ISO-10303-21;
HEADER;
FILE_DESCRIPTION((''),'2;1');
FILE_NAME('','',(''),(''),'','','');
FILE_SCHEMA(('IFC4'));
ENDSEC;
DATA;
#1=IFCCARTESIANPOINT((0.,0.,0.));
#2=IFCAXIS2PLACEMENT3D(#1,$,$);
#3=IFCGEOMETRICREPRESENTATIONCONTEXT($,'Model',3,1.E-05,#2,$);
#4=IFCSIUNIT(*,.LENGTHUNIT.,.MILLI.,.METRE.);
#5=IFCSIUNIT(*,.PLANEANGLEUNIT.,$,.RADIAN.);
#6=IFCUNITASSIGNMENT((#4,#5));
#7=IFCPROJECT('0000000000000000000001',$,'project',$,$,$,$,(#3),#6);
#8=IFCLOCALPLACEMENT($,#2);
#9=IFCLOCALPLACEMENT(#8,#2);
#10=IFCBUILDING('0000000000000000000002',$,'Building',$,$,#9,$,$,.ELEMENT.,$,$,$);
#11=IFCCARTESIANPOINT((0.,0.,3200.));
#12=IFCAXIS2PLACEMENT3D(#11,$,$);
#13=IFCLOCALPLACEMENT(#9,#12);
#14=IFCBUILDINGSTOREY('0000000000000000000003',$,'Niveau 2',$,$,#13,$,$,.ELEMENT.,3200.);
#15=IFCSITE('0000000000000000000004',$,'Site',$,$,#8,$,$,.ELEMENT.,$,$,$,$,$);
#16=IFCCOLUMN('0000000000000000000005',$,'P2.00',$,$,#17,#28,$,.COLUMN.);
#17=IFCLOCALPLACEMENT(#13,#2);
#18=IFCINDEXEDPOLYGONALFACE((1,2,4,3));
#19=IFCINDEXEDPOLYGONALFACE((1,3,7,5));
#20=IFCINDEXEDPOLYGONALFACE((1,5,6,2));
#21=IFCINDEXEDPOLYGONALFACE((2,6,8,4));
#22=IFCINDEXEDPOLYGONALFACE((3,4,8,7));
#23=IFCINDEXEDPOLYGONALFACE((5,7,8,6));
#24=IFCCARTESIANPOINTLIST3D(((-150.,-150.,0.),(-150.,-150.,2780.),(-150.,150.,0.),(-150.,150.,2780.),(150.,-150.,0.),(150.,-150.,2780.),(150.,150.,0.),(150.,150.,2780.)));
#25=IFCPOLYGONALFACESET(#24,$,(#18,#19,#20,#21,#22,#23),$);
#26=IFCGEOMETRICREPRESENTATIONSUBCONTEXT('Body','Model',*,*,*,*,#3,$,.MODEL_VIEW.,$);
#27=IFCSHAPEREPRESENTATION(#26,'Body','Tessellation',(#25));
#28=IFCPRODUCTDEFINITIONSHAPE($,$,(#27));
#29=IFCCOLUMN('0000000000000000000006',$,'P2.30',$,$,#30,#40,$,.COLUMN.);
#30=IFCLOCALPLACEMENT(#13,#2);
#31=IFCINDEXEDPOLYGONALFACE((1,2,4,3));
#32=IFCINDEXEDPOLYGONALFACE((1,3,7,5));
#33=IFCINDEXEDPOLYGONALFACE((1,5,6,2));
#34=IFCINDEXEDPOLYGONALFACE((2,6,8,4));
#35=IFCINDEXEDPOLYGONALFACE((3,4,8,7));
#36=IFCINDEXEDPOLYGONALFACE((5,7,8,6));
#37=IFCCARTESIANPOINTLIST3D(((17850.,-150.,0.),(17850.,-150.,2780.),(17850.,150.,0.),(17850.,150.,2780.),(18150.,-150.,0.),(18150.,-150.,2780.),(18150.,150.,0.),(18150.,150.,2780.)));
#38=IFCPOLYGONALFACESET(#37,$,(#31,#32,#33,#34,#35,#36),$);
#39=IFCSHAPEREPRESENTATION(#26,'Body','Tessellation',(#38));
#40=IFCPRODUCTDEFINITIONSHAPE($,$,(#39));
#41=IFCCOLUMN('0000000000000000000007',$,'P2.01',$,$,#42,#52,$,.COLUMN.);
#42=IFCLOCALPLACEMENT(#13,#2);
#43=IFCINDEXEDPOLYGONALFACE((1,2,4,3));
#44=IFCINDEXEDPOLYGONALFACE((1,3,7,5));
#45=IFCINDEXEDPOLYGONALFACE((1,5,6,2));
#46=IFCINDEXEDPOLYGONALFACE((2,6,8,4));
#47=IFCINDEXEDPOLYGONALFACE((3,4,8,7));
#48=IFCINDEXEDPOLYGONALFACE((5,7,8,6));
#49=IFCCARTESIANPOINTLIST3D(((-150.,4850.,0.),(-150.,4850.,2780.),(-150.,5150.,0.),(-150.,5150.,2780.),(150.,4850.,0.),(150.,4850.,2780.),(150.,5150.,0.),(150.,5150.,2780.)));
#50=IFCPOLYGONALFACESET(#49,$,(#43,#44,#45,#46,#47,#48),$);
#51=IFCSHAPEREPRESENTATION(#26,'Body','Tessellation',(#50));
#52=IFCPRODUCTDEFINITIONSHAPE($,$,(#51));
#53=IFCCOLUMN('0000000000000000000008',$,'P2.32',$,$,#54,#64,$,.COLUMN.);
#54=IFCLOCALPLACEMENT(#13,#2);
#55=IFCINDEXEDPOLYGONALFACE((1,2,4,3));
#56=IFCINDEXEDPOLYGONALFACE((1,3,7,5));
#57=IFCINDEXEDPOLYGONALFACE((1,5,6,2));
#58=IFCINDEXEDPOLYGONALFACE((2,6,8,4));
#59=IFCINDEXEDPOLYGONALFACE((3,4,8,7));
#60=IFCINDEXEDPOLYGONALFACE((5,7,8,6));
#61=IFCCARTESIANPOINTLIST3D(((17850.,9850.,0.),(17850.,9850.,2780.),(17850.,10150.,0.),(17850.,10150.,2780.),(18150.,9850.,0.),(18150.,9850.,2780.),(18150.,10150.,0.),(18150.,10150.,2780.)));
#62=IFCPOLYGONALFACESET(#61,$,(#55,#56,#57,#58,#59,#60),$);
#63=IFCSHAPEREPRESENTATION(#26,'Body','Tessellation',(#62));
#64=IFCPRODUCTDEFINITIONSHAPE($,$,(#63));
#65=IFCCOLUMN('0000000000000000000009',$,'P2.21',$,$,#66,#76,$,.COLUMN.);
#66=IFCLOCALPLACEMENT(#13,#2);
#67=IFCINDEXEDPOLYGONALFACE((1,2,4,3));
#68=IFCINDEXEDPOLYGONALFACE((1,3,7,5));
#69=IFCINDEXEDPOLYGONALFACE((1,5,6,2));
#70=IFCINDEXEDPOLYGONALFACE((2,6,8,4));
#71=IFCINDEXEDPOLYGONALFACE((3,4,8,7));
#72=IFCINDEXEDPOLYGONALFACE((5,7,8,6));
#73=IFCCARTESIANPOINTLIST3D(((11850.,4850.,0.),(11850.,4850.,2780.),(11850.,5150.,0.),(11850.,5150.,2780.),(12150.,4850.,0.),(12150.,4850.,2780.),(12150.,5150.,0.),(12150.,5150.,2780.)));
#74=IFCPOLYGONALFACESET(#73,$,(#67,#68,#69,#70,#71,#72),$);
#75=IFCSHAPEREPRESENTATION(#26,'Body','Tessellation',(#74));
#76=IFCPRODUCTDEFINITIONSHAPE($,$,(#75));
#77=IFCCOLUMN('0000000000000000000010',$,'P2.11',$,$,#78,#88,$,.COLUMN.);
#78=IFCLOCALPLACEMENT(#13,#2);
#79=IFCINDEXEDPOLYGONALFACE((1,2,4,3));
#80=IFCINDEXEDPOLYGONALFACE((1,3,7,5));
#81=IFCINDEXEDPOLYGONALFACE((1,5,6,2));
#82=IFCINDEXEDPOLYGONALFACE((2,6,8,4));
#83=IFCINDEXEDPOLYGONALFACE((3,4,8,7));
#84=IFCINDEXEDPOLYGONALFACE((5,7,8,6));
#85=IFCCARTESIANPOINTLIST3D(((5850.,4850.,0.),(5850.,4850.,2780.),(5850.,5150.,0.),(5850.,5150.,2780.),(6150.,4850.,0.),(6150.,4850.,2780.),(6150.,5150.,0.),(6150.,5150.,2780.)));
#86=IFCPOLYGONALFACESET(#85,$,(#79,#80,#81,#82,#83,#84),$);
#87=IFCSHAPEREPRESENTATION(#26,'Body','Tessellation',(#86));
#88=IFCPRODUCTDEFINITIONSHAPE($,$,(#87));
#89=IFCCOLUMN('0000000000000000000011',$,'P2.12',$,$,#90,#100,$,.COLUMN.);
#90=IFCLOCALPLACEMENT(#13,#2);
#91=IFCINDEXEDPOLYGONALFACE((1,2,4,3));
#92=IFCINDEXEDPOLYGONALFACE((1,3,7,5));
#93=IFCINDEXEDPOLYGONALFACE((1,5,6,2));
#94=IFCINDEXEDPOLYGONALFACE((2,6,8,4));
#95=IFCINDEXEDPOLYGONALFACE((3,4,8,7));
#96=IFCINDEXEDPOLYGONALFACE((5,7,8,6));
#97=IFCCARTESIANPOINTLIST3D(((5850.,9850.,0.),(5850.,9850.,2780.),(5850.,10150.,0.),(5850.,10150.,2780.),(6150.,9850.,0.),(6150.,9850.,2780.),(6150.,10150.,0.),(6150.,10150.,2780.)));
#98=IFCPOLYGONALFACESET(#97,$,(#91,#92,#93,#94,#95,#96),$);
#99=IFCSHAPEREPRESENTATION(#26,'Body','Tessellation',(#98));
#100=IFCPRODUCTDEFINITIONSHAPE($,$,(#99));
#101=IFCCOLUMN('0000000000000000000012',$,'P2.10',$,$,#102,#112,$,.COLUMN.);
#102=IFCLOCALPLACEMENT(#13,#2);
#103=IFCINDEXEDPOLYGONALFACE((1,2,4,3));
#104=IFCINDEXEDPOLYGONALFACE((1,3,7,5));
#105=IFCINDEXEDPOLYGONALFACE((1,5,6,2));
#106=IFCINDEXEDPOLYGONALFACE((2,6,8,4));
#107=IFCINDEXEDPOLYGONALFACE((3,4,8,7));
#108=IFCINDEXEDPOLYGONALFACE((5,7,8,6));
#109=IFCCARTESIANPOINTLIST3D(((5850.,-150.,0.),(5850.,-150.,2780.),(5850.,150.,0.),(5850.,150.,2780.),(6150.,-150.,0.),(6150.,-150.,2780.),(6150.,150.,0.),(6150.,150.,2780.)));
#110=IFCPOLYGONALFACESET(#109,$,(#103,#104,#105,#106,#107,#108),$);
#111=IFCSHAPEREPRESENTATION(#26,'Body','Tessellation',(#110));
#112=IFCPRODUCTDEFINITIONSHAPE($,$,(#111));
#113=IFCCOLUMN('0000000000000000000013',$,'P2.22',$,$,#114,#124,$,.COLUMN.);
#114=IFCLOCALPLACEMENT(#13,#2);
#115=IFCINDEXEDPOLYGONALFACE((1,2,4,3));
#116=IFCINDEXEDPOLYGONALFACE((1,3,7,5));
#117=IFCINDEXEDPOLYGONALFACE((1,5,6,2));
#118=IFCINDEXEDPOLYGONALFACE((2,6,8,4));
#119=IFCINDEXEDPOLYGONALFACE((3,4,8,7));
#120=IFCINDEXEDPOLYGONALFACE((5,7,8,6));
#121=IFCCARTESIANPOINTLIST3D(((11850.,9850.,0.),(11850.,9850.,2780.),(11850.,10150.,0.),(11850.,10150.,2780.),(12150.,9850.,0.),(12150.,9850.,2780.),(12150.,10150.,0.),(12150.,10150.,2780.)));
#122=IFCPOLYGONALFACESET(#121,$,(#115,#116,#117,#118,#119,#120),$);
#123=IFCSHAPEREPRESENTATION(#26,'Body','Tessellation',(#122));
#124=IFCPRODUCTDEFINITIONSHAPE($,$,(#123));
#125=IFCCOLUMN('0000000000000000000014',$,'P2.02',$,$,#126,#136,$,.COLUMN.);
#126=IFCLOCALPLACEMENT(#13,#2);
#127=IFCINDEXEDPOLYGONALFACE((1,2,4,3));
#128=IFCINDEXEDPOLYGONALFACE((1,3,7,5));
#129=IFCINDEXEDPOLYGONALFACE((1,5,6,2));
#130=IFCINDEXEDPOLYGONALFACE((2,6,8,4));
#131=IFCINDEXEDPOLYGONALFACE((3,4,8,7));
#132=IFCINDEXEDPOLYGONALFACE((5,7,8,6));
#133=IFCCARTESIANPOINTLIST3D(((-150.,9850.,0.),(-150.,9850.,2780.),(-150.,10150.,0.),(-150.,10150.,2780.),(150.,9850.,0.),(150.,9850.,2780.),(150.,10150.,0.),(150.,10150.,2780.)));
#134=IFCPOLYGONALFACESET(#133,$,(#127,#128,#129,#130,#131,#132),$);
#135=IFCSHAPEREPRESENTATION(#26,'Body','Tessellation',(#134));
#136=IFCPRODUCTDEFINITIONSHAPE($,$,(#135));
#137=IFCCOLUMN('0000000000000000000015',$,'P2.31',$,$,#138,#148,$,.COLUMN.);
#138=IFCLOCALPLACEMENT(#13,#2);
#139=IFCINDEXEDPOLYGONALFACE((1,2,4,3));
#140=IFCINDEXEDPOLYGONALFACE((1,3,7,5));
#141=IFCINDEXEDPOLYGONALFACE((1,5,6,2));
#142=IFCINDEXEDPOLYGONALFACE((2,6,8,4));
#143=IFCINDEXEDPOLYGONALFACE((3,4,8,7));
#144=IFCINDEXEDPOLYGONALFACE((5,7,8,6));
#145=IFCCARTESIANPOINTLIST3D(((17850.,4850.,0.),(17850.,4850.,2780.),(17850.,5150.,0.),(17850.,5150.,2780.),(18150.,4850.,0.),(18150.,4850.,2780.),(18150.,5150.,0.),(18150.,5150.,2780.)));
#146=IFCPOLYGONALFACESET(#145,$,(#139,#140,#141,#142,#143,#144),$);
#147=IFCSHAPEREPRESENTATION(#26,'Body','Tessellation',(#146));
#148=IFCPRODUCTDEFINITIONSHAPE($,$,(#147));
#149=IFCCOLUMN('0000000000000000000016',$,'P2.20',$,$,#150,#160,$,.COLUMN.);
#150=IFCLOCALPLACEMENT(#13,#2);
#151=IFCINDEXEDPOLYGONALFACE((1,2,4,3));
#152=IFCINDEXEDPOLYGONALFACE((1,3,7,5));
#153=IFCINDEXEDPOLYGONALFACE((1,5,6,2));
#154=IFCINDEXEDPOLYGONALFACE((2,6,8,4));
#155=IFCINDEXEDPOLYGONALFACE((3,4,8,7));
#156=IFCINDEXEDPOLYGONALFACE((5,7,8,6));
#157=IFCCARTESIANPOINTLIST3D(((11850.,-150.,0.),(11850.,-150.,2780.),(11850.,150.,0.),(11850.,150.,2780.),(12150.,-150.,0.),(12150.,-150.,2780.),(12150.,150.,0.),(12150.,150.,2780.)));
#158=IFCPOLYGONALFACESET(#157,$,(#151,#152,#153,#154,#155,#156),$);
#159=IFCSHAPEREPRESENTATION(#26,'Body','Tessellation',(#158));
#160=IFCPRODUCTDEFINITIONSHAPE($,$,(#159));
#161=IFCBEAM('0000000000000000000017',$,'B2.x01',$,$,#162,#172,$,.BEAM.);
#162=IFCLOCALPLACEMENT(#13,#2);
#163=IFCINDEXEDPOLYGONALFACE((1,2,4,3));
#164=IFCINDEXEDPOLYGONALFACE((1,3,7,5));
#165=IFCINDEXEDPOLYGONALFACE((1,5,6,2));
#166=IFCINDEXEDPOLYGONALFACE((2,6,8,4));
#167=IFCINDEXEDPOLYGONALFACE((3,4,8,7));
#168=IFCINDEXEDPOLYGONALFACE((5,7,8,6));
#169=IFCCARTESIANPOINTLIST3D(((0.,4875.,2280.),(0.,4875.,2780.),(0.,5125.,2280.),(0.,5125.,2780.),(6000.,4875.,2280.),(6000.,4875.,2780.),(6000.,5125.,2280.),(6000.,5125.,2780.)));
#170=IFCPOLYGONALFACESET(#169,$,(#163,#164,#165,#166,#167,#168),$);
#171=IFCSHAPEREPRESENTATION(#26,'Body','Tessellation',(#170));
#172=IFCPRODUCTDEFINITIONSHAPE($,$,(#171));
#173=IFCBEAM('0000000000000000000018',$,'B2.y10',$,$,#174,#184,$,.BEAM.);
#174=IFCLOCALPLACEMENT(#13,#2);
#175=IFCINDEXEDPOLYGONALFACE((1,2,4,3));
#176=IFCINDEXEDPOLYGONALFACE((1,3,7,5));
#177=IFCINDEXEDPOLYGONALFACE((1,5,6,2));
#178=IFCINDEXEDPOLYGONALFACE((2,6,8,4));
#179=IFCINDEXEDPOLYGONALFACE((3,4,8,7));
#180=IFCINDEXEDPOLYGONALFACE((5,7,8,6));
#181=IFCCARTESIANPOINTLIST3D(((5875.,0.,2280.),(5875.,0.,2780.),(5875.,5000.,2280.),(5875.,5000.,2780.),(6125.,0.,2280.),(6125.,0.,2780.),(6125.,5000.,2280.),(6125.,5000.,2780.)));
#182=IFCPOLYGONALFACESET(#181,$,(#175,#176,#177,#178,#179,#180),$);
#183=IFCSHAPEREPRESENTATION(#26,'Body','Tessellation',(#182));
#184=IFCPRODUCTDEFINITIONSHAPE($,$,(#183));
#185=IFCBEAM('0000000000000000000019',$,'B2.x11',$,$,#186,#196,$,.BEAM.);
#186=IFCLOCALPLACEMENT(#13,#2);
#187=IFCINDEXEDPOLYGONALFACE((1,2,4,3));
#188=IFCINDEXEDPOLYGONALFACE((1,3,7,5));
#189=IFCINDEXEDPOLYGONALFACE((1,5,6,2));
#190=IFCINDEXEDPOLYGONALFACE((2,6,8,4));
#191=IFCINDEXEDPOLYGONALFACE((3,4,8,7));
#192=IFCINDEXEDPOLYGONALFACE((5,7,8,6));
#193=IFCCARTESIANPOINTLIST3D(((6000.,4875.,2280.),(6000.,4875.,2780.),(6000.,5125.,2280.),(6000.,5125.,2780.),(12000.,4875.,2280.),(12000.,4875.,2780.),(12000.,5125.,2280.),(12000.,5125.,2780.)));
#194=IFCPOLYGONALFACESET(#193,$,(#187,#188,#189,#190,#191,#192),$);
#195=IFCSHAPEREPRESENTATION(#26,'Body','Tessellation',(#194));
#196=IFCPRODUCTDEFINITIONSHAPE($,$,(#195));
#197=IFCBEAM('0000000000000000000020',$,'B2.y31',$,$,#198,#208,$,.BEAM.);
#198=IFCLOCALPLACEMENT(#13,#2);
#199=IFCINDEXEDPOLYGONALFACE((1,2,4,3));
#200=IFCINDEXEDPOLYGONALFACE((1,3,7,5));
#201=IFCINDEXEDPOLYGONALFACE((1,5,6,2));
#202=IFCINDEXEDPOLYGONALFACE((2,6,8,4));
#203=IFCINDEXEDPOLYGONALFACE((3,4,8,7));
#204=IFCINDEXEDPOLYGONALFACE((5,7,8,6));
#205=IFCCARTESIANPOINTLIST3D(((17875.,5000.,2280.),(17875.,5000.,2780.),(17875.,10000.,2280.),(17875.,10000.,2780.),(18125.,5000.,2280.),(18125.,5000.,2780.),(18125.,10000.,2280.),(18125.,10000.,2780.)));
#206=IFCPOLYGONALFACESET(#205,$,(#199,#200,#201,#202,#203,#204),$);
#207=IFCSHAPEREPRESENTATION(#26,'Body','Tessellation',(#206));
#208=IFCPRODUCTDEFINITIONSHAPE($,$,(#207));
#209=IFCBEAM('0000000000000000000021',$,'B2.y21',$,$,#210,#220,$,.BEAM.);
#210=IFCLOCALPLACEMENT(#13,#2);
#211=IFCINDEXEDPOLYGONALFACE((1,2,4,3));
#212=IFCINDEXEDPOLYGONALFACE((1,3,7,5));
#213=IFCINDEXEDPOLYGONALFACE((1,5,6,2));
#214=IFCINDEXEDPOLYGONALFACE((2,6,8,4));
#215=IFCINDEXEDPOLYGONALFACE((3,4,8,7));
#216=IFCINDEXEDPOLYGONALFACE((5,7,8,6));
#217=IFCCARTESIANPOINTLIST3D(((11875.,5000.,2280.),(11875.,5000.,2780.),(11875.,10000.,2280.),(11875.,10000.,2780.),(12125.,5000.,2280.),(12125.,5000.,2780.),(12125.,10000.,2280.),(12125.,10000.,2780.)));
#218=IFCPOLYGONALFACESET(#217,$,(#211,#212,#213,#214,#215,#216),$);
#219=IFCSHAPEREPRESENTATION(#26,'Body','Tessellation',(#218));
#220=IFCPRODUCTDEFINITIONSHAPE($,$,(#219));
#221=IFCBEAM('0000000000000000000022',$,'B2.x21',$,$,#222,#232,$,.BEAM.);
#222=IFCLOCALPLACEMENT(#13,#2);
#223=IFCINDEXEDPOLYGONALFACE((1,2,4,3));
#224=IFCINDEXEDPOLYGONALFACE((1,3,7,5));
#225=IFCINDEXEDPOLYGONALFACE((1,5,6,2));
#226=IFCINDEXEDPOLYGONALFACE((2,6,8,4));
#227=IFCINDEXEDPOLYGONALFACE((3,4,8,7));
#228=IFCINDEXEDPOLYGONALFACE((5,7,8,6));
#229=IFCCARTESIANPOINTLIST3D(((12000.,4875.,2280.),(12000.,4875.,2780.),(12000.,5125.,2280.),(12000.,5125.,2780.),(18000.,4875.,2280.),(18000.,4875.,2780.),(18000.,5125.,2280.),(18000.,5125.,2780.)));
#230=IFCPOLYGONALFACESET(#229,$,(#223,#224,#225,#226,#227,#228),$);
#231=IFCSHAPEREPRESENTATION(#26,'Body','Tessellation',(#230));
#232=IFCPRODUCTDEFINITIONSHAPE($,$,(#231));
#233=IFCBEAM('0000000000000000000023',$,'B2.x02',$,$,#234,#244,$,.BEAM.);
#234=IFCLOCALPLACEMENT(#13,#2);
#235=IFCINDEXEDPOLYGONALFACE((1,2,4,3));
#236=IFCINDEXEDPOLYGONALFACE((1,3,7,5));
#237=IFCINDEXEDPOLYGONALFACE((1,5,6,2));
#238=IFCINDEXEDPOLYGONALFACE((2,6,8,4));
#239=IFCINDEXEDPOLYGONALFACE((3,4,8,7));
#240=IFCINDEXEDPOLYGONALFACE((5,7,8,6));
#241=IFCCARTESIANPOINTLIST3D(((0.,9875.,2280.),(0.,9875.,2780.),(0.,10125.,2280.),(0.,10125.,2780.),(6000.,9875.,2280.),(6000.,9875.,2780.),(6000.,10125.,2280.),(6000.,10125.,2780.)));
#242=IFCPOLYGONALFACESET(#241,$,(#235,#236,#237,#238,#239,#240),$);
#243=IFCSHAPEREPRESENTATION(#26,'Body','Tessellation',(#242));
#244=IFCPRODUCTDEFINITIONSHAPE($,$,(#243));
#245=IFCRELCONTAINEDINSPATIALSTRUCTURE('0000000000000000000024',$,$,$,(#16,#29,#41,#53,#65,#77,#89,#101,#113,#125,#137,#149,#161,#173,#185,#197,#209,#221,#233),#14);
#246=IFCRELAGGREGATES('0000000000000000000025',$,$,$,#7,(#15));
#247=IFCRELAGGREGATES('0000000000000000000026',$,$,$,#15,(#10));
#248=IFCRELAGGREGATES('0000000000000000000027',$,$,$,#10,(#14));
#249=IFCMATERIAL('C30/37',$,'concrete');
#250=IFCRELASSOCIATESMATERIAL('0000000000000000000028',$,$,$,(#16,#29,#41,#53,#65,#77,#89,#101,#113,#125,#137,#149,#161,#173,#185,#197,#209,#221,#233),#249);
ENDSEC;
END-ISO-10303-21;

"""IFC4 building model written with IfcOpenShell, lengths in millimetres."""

from ifc_helpers import new_model, si_unit, frame, origin, place, context, subcontext, project, spatial, rectangle, extrude, material, element, save


model = new_model("IFC4")

# Units and contexts
model_context = context("Model", 3, precision=1e-05, world=origin())
body_context = subcontext(model_context, "Body", "Model", "MODEL_VIEW")
ifc_project = project(units=[si_unit("LENGTHUNIT", "METRE", prefix="MILLI"), si_unit("PLANEANGLEUNIT", "RADIAN")], contexts=[model_context])

# Site, building, storey
site_placement = place(None, origin())
site = spatial("IfcSite", under=ifc_project, at=site_placement, Name="Site", CompositionType="ELEMENT")
building_placement = place(site_placement, origin())
building = spatial("IfcBuilding", under=site, at=building_placement, Name="Building", CompositionType="ELEMENT")
storey_placement = place(building_placement, frame((0.0, 0.0, 3200.0)))
storey = spatial("IfcBuildingStorey", under=building, at=storey_placement, Name="Niveau 2", CompositionType="ELEMENT", Elevation=3200.0)

# Columns
ifc_material = material(Name="C30/37", Category="concrete")
for number, where, z_axis, x_axis, name in (
    (1, (0.0, 0.0, 0.0), (0.0, 0.0, 1.0), (1.0, 0.0, 0.0), "P2.00"),
    (2, (18000.0, 0.0, 0.0), (0.0, 0.0, 1.0), (1.0, 0.0, 0.0), "P2.30"),
    (3, (0.0, 5000.0, 0.0), (0.0, 0.0, 1.0), (1.0, 0.0, 0.0), "P2.01"),
    (4, (18000.0, 10000.0, 0.0), (0.0, 0.0, 1.0), (1.0, 0.0, 0.0), "P2.32"),
    (5, (12000.0, 5000.0, 0.0), (0.0, 0.0, 1.0), (1.0, 0.0, 0.0), "P2.21"),
    (6, (6000.0, 5000.0, 0.0), (0.0, 0.0, 1.0), (1.0, 0.0, 0.0), "P2.11"),
    (7, (6000.0, 10000.0, 0.0), (0.0, 0.0, 1.0), (1.0, 0.0, 0.0), "P2.12"),
    (8, (6000.0, 0.0, 0.0), (0.0, 0.0, 1.0), (1.0, 0.0, 0.0), "P2.10"),
    (9, (12000.0, 10000.0, 0.0), (0.0, 0.0, 1.0), (1.0, 0.0, 0.0), "P2.22"),
    (10, (0.0, 10000.0, 0.0), (0.0, 0.0, 1.0), (1.0, 0.0, 0.0), "P2.02"),
    (11, (18000.0, 5000.0, 0.0), (0.0, 0.0, 1.0), (1.0, 0.0, 0.0), "P2.31"),
    (12, (12000.0, 0.0, 0.0), (0.0, 0.0, 1.0), (1.0, 0.0, 0.0), "P2.20"),
):
    element("IfcColumn", number, at=place(storey_placement, frame(where, z_axis=z_axis, x_axis=x_axis)), inside=storey, material=ifc_material, Name=name, PredefinedType="COLUMN", context=body_context, shape_type="SweptSolid", body=[
        extrude(rectangle(XDim=300.0, YDim=300.0), origin(), (0.0, 0.0, 1.0), 2780.0),
    ])

# Beams
beam_1_placement = place(storey_placement, frame((0.0, 5000.0, 2530.0), z_axis=(1.0, 0.0, 0.0), x_axis=(0.0, 1.0, 0.0)))
element("IfcBeam", 13, at=beam_1_placement, inside=storey, material=ifc_material, Name="B2.x01", PredefinedType="BEAM", context=body_context, shape_type="SweptSolid", body=[
    extrude(rectangle(XDim=250.0, YDim=500.0), origin(), (0.0, 0.0, 1.0), 6000.0),
])
beam_2_placement = place(storey_placement, frame((6000.0, 0.0, 2530.0), z_axis=(0.0, 1.0, 0.0), x_axis=(-1.0, 0.0, 0.0)))
element("IfcBeam", 14, at=beam_2_placement, inside=storey, material=ifc_material, Name="B2.y10", PredefinedType="BEAM", context=body_context, shape_type="SweptSolid", body=[
    extrude(rectangle(XDim=250.0, YDim=500.0), origin(), (0.0, 0.0, 1.0), 5000.0),
])
beam_3_placement = place(storey_placement, frame((6000.0, 5000.0, 2530.0), z_axis=(1.0, 0.0, 0.0), x_axis=(0.0, 1.0, 0.0)))
element("IfcBeam", 15, at=beam_3_placement, inside=storey, material=ifc_material, Name="B2.x11", PredefinedType="BEAM", context=body_context, shape_type="SweptSolid", body=[
    extrude(rectangle(XDim=250.0, YDim=500.0), origin(), (0.0, 0.0, 1.0), 6000.0),
])
for number, where, z_axis, x_axis, name in (
    (16, (18000.0, 5000.0, 2530.0), (0.0, 1.0, 0.0), (-1.0, 0.0, 0.0), "B2.y31"),
    (17, (12000.0, 5000.0, 2530.0), (0.0, 1.0, 0.0), (-1.0, 0.0, 0.0), "B2.y21"),
):
    element("IfcBeam", number, at=place(storey_placement, frame(where, z_axis=z_axis, x_axis=x_axis)), inside=storey, material=ifc_material, Name=name, PredefinedType="BEAM", context=body_context, shape_type="SweptSolid", body=[
        extrude(rectangle(XDim=250.0, YDim=500.0), origin(), (0.0, 0.0, 1.0), 5000.0),
    ])
for number, where, z_axis, x_axis, name in (
    (18, (12000.0, 5000.0, 2530.0), (1.0, 0.0, 0.0), (0.0, 1.0, 0.0), "B2.x21"),
    (19, (0.0, 10000.0, 2530.0), (1.0, 0.0, 0.0), (0.0, 1.0, 0.0), "B2.x02"),
):
    element("IfcBeam", number, at=place(storey_placement, frame(where, z_axis=z_axis, x_axis=x_axis)), inside=storey, material=ifc_material, Name=name, PredefinedType="BEAM", context=body_context, shape_type="SweptSolid", body=[
        extrude(rectangle(XDim=250.0, YDim=500.0), origin(), (0.0, 0.0, 1.0), 6000.0),
    ])

save(model, "model.ifc")
